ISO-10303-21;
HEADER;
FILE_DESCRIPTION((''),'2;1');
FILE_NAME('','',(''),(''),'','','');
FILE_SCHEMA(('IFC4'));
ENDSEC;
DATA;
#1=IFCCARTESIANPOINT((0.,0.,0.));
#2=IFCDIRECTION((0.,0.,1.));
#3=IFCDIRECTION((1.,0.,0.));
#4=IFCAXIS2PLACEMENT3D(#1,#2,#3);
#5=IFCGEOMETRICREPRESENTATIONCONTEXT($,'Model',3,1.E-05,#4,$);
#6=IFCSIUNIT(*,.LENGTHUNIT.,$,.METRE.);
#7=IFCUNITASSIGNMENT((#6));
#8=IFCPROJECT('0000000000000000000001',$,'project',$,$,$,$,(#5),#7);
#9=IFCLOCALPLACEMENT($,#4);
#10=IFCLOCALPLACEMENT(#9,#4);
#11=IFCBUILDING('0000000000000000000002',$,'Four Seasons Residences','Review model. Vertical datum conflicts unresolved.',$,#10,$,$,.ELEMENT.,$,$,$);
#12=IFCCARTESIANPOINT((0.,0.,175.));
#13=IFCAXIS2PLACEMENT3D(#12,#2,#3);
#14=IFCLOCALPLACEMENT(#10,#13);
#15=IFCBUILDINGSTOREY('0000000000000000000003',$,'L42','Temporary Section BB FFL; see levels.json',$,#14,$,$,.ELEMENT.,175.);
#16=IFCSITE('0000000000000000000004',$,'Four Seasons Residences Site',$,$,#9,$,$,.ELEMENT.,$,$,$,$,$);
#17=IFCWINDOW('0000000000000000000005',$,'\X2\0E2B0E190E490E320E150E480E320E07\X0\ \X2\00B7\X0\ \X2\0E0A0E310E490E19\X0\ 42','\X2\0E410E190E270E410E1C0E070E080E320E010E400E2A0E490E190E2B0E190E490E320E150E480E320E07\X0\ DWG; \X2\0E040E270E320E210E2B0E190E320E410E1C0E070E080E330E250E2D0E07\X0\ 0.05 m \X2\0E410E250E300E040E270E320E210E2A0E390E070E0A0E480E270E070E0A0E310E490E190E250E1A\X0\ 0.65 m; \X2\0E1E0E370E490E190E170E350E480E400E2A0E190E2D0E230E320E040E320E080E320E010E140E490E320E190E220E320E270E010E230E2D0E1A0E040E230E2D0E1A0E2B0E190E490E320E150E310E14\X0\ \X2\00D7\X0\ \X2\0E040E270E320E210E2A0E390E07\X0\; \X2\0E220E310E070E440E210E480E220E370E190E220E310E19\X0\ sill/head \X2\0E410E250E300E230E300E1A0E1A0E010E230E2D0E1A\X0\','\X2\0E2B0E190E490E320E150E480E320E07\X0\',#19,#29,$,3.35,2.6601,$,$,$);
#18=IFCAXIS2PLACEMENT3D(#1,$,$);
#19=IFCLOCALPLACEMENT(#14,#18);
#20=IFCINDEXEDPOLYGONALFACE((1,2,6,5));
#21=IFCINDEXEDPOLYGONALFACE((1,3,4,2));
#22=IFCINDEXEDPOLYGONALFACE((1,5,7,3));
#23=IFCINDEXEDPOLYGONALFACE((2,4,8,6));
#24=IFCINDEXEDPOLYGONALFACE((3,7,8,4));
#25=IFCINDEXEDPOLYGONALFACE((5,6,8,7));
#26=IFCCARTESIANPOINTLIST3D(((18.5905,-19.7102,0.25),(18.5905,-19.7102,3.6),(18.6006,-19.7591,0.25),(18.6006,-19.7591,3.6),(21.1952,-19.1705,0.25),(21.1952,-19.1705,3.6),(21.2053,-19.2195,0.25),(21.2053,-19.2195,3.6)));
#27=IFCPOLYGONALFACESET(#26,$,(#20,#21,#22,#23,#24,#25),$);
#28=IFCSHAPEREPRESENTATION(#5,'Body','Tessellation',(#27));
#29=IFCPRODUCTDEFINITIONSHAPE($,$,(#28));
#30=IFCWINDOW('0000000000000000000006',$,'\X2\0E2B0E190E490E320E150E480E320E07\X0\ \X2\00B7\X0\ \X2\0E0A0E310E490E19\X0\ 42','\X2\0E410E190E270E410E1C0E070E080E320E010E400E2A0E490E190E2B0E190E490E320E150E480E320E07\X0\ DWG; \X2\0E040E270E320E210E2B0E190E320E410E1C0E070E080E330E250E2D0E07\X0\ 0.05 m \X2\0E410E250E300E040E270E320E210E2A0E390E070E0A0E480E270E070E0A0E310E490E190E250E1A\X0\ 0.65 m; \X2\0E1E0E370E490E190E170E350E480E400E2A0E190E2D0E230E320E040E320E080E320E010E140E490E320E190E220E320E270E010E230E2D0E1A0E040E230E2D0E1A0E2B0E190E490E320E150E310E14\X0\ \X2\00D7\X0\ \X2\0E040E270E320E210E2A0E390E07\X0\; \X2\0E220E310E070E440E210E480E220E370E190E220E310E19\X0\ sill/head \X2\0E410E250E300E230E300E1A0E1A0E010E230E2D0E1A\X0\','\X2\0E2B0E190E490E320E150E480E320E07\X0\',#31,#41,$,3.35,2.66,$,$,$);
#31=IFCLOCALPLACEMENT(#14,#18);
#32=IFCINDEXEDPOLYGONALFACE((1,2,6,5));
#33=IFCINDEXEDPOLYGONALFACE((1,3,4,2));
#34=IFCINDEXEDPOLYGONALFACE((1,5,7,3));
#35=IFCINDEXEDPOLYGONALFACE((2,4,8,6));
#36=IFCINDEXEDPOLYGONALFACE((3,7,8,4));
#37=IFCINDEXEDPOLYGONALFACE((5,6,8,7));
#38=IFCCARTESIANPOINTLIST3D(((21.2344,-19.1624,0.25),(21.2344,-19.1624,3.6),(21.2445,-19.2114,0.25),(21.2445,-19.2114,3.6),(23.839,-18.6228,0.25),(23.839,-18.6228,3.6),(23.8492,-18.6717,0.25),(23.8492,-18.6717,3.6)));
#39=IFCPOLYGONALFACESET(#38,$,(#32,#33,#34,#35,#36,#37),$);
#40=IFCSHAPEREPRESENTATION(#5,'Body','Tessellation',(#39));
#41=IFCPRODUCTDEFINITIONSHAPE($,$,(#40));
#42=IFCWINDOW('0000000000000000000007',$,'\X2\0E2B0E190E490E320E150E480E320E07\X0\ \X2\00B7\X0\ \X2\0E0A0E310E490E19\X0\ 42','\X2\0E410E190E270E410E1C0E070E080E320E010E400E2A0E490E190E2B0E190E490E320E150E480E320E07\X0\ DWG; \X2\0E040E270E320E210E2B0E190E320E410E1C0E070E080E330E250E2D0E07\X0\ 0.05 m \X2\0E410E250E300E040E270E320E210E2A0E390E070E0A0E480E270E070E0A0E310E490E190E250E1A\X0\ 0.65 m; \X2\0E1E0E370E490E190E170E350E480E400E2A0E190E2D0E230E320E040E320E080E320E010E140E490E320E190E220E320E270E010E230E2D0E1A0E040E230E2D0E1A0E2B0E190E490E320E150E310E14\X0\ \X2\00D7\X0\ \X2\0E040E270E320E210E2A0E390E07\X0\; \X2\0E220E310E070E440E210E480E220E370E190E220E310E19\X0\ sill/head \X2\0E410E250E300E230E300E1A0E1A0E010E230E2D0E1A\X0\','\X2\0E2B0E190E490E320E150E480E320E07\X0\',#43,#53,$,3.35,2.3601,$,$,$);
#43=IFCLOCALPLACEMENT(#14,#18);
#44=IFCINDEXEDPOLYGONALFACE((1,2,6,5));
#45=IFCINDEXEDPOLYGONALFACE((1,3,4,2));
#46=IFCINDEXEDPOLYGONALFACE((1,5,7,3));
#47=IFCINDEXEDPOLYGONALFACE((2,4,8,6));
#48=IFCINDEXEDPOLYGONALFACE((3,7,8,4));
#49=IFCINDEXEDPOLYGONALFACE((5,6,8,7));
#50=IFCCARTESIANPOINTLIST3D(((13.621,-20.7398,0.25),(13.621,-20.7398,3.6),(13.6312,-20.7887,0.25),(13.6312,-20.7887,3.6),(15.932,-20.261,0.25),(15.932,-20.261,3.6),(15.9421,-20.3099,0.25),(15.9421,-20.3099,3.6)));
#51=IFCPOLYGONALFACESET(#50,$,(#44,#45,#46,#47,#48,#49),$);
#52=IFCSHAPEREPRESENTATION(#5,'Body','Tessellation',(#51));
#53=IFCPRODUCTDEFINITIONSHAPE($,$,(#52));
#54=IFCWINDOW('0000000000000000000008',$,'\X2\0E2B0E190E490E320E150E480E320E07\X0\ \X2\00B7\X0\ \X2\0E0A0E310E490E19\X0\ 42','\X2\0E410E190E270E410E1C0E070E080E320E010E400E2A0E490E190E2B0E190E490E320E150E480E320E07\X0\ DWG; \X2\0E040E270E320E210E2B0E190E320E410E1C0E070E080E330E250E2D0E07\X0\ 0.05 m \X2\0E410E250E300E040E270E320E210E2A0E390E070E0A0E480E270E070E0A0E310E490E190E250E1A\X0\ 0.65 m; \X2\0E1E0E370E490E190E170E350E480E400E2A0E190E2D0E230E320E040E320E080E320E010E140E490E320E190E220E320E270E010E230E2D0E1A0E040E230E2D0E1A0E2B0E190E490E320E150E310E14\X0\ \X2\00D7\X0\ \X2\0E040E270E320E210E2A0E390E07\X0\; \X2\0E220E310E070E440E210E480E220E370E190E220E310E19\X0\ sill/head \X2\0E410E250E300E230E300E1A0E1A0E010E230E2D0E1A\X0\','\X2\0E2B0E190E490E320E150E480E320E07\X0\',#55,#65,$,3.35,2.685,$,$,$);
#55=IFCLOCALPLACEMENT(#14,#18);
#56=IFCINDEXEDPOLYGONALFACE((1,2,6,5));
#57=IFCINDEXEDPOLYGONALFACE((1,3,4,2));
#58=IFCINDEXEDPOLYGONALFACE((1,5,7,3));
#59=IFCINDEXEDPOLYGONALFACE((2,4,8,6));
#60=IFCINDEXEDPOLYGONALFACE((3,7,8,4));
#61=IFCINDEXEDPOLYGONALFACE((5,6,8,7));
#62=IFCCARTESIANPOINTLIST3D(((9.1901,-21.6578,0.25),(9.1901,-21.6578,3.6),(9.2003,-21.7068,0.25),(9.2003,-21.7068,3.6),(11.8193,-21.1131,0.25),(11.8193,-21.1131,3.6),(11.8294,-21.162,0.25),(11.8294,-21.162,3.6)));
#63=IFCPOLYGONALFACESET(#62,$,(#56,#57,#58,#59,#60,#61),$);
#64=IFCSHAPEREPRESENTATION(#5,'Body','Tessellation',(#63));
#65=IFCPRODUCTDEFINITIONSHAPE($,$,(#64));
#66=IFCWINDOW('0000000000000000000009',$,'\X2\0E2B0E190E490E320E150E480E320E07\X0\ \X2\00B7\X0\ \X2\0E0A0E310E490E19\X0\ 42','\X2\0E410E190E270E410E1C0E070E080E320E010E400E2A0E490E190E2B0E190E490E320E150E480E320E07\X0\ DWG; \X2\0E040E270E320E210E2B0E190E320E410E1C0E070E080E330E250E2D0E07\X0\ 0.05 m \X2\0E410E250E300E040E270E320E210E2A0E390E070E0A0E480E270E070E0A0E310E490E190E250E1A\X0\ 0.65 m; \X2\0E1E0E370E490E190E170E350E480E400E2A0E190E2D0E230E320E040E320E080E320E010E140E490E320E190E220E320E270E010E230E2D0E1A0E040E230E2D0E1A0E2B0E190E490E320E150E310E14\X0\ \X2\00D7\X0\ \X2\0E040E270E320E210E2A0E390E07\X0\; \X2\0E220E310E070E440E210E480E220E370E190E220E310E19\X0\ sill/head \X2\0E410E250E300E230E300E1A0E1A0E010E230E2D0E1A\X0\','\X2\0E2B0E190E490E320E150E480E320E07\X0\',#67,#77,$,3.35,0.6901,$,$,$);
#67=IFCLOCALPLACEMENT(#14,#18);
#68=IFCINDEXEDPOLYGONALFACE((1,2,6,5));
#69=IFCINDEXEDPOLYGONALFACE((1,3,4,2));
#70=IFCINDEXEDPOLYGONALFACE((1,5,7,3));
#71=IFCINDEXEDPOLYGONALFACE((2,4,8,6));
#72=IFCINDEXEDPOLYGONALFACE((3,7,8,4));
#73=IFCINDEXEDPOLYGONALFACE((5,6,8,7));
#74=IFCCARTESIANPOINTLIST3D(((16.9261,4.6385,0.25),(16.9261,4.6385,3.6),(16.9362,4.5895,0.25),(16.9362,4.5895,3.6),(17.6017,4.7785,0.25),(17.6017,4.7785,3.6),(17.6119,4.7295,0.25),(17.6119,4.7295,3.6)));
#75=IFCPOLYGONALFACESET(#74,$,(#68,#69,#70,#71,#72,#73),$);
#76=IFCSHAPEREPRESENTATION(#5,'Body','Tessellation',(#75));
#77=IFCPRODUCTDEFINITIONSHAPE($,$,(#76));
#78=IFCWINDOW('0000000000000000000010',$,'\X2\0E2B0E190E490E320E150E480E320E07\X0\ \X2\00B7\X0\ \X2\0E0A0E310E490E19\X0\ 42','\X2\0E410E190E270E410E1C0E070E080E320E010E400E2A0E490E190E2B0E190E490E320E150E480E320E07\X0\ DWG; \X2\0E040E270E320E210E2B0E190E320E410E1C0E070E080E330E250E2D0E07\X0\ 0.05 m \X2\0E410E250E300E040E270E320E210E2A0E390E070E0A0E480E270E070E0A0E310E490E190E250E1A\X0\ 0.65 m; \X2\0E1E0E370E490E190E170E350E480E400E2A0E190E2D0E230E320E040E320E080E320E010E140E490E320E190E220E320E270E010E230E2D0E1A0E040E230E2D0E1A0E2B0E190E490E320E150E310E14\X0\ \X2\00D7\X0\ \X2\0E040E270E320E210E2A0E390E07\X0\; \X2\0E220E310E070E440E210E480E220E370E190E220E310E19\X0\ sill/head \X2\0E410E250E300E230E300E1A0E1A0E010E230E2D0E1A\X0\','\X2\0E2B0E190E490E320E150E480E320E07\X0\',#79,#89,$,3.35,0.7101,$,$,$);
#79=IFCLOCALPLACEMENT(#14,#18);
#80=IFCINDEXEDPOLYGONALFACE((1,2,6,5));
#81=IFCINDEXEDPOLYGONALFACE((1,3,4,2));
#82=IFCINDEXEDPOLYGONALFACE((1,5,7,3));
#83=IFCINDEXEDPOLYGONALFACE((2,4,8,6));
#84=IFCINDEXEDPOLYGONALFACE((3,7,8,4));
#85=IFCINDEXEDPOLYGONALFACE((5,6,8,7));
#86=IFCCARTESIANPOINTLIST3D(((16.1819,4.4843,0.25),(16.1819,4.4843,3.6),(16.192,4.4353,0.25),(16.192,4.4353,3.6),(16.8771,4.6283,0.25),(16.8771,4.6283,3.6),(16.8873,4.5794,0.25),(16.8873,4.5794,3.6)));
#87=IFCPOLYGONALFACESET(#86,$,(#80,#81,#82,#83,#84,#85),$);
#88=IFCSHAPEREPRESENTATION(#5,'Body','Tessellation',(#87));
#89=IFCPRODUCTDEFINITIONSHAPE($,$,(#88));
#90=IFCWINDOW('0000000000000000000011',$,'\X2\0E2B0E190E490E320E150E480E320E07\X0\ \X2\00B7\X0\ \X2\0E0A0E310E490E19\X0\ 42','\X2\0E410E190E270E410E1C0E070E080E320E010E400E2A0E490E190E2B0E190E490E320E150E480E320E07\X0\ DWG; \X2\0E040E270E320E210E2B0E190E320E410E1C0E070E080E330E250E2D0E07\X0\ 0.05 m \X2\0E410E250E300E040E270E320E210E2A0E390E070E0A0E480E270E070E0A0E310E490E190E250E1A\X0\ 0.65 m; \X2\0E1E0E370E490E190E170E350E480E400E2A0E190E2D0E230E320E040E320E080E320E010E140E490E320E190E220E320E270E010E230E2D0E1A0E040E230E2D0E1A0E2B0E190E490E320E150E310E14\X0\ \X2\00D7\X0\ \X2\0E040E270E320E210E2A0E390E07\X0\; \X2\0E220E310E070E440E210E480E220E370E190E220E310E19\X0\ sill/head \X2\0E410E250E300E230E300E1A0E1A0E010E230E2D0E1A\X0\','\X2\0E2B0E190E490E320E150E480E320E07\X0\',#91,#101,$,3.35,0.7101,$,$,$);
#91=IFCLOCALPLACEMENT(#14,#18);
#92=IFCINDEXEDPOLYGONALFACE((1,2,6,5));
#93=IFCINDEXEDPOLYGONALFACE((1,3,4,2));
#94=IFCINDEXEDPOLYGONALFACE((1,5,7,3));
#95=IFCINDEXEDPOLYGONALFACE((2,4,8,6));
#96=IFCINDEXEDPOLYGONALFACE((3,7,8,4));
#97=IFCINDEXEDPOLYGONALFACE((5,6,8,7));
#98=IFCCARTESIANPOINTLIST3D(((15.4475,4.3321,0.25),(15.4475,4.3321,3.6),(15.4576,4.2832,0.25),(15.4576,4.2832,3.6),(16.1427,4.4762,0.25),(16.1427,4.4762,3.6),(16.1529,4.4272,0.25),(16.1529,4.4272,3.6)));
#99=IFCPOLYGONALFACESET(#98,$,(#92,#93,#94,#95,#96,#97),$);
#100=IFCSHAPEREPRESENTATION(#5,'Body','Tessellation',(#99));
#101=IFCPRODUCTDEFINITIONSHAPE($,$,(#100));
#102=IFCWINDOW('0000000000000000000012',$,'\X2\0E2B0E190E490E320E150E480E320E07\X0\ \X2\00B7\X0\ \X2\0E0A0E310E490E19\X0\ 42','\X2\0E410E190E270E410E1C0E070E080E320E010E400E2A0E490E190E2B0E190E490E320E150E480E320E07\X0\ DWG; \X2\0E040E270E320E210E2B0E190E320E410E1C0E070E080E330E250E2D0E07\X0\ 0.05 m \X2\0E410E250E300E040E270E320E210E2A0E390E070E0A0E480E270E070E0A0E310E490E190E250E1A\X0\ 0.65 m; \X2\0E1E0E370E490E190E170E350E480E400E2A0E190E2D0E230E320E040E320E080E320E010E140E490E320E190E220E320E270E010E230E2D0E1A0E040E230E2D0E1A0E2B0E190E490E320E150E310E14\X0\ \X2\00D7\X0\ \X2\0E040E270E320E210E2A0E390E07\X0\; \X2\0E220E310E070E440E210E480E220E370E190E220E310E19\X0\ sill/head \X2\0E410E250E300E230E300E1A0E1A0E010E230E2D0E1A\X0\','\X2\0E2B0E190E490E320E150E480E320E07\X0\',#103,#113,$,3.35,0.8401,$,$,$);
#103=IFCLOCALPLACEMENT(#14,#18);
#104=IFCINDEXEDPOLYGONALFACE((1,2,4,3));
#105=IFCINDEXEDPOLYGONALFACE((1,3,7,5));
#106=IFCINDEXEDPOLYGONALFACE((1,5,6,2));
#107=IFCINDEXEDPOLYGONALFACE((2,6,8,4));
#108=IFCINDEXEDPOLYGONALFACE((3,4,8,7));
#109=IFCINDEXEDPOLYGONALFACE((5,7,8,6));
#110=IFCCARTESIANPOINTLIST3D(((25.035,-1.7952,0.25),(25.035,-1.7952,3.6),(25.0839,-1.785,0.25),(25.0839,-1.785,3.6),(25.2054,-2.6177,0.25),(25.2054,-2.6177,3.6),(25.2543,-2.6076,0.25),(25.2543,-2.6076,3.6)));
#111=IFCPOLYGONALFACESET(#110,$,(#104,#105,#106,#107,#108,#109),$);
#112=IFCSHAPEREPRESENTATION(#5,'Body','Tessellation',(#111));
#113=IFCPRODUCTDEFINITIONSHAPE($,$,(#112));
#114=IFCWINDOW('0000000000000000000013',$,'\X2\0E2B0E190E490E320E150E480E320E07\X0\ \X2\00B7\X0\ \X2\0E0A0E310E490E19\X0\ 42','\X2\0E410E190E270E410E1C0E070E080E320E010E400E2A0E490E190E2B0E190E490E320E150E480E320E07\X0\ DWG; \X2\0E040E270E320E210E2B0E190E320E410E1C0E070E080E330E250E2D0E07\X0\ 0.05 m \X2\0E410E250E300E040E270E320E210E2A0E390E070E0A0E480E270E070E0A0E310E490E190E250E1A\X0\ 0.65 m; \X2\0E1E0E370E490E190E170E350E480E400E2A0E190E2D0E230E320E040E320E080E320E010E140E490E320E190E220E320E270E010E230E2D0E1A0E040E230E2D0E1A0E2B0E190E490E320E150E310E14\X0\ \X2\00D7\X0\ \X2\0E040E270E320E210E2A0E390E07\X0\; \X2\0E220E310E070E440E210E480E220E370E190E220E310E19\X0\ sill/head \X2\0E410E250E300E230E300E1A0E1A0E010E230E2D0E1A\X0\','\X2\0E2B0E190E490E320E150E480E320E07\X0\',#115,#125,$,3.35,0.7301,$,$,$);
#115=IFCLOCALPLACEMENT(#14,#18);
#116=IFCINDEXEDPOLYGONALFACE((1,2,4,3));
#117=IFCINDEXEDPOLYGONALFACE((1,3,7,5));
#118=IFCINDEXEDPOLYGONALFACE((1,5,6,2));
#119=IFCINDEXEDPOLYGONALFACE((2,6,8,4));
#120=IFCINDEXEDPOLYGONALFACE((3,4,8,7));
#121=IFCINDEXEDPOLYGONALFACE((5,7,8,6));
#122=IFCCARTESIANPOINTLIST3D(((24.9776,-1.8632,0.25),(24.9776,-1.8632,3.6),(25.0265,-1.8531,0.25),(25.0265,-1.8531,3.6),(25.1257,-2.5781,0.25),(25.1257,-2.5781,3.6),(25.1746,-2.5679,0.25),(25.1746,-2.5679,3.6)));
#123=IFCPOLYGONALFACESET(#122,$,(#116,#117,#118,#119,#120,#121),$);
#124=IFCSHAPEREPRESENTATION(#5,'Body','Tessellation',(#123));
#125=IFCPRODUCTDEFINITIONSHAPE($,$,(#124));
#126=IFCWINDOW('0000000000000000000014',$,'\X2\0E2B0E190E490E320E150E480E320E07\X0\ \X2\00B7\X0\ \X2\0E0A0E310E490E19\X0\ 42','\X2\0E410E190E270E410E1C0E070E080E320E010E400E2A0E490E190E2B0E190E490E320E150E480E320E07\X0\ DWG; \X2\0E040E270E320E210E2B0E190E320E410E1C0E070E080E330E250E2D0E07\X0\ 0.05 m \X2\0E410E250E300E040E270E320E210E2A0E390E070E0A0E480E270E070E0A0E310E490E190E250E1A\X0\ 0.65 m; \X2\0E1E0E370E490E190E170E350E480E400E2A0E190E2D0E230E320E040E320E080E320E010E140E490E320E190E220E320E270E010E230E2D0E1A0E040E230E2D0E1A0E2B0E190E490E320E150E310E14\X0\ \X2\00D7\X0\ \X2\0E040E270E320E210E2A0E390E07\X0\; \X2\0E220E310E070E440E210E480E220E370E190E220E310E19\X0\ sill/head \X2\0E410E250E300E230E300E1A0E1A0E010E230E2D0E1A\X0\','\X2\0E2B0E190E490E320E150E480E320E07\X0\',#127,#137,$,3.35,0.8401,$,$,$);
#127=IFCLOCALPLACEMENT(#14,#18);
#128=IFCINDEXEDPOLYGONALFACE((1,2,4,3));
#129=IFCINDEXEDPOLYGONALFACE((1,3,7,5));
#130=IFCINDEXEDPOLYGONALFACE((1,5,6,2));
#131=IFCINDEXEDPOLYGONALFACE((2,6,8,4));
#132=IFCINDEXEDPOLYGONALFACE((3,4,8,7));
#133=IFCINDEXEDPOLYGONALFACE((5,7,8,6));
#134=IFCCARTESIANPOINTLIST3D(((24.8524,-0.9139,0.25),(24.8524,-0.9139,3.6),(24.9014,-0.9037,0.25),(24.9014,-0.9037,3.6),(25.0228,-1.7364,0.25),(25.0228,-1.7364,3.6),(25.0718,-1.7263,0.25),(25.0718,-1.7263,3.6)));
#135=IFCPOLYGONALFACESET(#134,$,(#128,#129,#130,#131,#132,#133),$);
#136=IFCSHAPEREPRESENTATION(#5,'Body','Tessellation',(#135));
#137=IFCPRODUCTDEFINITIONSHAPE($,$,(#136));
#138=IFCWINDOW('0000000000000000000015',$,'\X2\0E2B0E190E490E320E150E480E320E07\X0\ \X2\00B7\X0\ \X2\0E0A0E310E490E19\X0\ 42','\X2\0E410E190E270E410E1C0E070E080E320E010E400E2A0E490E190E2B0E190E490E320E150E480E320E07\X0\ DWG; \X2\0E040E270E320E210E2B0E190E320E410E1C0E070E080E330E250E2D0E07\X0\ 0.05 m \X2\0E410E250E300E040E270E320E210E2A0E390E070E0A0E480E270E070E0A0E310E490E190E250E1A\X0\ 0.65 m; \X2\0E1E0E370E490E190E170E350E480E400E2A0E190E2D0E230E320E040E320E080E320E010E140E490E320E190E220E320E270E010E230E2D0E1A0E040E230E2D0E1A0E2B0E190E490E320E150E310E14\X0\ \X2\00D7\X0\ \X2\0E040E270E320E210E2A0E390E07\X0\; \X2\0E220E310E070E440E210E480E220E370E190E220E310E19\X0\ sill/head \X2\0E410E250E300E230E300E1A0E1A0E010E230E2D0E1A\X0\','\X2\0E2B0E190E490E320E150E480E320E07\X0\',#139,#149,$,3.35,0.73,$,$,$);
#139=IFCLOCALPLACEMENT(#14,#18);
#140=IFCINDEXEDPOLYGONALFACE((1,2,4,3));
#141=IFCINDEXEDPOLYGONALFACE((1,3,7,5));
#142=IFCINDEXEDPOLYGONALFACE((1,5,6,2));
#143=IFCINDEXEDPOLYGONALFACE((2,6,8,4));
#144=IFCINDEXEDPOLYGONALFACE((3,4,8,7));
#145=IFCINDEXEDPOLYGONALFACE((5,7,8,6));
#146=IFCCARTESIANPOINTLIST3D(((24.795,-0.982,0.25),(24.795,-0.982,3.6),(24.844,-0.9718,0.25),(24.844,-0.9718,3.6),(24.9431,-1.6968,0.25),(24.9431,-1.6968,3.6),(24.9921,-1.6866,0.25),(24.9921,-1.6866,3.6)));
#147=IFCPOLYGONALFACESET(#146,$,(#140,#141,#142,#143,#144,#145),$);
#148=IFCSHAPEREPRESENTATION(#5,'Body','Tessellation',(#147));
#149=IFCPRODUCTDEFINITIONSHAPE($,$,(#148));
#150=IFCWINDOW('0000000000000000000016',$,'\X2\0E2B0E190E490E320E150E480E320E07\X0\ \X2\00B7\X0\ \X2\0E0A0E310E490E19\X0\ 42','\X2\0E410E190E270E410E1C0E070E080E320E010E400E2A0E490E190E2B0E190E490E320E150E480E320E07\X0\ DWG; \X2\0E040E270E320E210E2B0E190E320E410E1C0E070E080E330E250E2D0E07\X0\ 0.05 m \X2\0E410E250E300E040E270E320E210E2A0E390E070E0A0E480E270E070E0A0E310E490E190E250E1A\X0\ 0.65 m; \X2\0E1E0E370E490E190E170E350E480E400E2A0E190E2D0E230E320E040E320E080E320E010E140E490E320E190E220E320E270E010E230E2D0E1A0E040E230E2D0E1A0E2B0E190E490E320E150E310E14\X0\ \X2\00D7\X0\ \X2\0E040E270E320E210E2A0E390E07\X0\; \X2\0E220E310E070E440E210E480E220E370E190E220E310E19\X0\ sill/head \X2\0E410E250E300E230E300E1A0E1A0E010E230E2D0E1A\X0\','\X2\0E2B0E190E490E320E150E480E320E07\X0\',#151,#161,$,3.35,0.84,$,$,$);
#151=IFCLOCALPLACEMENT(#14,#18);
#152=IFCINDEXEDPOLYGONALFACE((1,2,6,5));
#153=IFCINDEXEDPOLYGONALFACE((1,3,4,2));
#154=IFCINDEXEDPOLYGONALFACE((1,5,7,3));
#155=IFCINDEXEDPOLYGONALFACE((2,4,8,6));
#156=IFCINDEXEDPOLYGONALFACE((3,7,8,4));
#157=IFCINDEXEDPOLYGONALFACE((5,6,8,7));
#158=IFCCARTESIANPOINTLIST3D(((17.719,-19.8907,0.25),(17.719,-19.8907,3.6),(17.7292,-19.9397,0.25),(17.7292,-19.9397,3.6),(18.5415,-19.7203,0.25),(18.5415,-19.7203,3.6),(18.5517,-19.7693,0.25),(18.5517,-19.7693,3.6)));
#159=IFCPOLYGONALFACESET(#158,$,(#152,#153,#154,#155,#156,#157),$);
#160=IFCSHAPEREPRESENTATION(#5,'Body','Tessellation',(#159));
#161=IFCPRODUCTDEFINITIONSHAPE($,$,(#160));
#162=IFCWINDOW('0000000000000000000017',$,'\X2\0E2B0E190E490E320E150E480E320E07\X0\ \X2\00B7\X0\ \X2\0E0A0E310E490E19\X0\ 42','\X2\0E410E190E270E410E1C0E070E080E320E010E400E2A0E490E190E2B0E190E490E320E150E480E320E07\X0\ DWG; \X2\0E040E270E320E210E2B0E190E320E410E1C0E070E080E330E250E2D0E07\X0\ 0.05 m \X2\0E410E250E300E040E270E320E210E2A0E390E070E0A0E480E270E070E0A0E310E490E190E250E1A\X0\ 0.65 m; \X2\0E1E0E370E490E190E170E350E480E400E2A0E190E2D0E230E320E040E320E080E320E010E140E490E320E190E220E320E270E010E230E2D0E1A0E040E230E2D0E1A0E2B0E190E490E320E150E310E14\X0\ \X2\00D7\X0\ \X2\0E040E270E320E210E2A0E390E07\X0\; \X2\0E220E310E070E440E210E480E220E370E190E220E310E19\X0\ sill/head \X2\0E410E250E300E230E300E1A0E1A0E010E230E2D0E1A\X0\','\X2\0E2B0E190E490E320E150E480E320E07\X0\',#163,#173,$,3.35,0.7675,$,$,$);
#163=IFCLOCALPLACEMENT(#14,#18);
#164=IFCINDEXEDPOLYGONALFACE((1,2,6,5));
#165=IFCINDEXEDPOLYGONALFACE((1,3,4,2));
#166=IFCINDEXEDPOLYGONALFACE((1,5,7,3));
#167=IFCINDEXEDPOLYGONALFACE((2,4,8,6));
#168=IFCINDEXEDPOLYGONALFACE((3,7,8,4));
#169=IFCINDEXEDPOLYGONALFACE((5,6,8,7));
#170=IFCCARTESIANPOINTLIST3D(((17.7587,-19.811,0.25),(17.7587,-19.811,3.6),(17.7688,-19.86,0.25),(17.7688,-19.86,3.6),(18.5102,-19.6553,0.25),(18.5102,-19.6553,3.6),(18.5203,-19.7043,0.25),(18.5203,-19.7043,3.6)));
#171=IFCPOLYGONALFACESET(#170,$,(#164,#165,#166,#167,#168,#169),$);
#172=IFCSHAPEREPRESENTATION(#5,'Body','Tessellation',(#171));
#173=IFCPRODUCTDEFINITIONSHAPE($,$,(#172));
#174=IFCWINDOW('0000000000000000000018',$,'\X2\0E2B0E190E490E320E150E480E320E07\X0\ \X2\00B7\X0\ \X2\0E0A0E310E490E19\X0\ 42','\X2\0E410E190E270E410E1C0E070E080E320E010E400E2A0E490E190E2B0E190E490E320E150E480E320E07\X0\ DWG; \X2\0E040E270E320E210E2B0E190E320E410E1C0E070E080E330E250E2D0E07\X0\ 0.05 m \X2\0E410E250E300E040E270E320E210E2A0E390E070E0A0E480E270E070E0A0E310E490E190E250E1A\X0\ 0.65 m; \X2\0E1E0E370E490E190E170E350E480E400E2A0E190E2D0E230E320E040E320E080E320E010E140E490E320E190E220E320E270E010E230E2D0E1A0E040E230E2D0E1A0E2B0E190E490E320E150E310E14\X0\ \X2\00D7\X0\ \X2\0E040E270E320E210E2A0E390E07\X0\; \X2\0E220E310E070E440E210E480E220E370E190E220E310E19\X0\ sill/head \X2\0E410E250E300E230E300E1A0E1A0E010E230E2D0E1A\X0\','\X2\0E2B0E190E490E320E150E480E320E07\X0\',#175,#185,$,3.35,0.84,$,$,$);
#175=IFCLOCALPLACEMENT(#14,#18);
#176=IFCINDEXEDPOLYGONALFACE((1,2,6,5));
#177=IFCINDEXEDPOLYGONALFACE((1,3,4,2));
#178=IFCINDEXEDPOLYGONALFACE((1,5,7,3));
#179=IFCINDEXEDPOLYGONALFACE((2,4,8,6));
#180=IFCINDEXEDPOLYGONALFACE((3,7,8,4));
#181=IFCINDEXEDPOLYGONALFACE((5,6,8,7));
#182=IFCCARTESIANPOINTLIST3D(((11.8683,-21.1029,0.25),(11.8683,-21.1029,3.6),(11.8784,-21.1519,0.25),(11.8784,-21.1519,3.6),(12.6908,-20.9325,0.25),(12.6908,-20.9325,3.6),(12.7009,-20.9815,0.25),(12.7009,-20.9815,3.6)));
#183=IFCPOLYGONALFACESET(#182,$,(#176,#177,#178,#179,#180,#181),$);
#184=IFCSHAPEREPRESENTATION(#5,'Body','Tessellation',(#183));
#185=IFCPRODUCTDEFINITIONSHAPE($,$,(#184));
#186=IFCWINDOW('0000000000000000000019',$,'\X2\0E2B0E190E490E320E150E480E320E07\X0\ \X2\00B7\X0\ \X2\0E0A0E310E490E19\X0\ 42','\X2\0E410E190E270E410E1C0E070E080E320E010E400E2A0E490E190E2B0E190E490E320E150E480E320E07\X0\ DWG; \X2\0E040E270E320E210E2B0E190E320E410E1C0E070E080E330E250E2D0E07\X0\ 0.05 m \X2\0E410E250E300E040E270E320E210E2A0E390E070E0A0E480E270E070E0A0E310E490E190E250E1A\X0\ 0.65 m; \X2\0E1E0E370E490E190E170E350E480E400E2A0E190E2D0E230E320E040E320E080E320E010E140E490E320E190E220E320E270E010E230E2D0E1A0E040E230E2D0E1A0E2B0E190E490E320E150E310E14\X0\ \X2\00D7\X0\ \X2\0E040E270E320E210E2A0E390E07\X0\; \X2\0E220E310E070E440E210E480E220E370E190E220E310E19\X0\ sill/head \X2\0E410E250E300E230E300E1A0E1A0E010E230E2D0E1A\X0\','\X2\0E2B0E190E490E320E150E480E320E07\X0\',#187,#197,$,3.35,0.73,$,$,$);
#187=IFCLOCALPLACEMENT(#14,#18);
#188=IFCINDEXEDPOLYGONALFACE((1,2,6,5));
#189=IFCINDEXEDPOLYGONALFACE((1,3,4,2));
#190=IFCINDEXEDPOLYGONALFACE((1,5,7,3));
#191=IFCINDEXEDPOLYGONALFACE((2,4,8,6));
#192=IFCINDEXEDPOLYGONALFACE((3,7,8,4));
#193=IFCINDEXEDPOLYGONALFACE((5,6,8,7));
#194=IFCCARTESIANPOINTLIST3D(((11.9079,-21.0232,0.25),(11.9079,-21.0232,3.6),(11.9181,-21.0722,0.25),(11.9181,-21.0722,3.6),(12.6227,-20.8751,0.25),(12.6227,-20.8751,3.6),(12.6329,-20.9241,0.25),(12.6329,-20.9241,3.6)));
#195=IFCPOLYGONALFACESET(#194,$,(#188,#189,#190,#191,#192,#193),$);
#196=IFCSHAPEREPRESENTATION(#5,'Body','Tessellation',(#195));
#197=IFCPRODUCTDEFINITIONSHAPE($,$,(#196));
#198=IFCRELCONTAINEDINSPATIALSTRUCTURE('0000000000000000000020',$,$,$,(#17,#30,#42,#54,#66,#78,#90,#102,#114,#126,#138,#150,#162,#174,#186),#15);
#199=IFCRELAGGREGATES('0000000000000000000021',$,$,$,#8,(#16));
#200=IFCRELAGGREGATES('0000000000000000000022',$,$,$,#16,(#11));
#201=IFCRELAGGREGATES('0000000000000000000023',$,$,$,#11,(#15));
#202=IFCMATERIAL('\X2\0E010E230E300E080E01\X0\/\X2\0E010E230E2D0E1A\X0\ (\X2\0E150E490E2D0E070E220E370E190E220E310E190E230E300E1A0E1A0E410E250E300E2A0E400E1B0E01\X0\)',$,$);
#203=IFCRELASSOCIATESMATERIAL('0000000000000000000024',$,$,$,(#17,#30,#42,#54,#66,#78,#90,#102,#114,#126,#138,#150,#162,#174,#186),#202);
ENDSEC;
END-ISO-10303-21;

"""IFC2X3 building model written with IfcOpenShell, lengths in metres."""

from ifc_helpers import new_model, si_unit, frame, origin_with_axes, place, context, project, spatial, polyline, outline, extrude, material, element, save


model = new_model("IFC2X3")

# Units and contexts
model_context = context("Model", 3, precision=1e-05, world=origin_with_axes())
ifc_project = project(units=[si_unit("LENGTHUNIT", "METRE")], contexts=[model_context])

# Site, building, storey
site_placement = place(None, origin_with_axes())
site = spatial("IfcSite", under=ifc_project, at=site_placement, Name="Four Seasons Residences Site", CompositionType="ELEMENT")
building_placement = place(site_placement, origin_with_axes())
building = spatial("IfcBuilding", under=site, at=building_placement, Name="Four Seasons Residences", Description="Review model. Vertical datum conflicts unresolved.", CompositionType="ELEMENT")
storey_placement = place(building_placement, frame((0.0, 0.0, 175.0), z_axis=(0.0, 0.0, 1.0), x_axis=(1.0, 0.0, 0.0)))
storey = spatial("IfcBuildingStorey", under=building, at=storey_placement, Name="L42", Description="Temporary Section BB FFL; see levels.json", CompositionType="ELEMENT", Elevation=175.0)

# Windows
ifc_material = material(Name="กระจก/กรอบ (ต้องยืนยันระบบและสเปก)")
window_1_placement = place(storey_placement, origin_with_axes())
element("IfcWindow", 1, at=window_1_placement, inside=storey, material=ifc_material, Name="หน้าต่าง · ชั้น 42", Description="แนวแผงจากเส้นหน้าต่าง DWG; ความหนาแผงจำลอง 0.05 m และความสูงช่วงชั้นลบ 0.65 m; พื้นที่เสนอราคาจากด้านยาวกรอบครอบหน้าตัด × ความสูง; ยังไม่ยืนยัน sill/head และระบบกรอบ", ObjectType="หน้าต่าง", OverallHeight=3.35, OverallWidth=2.6601, context=model_context, shape_type="SweptSolid", body=[
    extrude(outline(polyline([(18.6006, -19.7591), (18.5905, -19.7102), (21.1952, -19.1705), (21.2053, -19.2195), (18.6006, -19.7591)])), frame((0.0, 0.0, 0.25), z_axis=(0.0, 0.0, 1.0), x_axis=(1.0, 0.0, 0.0)), (0.0, 0.0, 1.0), 3.35),
])
window_2_placement = place(storey_placement, origin_with_axes())
element("IfcWindow", 2, at=window_2_placement, inside=storey, material=ifc_material, Name="หน้าต่าง · ชั้น 42", Description="แนวแผงจากเส้นหน้าต่าง DWG; ความหนาแผงจำลอง 0.05 m และความสูงช่วงชั้นลบ 0.65 m; พื้นที่เสนอราคาจากด้านยาวกรอบครอบหน้าตัด × ความสูง; ยังไม่ยืนยัน sill/head และระบบกรอบ", ObjectType="หน้าต่าง", OverallHeight=3.35, OverallWidth=2.66, context=model_context, shape_type="SweptSolid", body=[
    extrude(outline(polyline([(21.2445, -19.2114), (21.2344, -19.1624), (23.839, -18.6228), (23.8492, -18.6717), (21.2445, -19.2114)])), frame((0.0, 0.0, 0.25), z_axis=(0.0, 0.0, 1.0), x_axis=(1.0, 0.0, 0.0)), (0.0, 0.0, 1.0), 3.35),
])
window_3_placement = place(storey_placement, origin_with_axes())
element("IfcWindow", 3, at=window_3_placement, inside=storey, material=ifc_material, Name="หน้าต่าง · ชั้น 42", Description="แนวแผงจากเส้นหน้าต่าง DWG; ความหนาแผงจำลอง 0.05 m และความสูงช่วงชั้นลบ 0.65 m; พื้นที่เสนอราคาจากด้านยาวกรอบครอบหน้าตัด × ความสูง; ยังไม่ยืนยัน sill/head และระบบกรอบ", ObjectType="หน้าต่าง", OverallHeight=3.35, OverallWidth=2.3601, context=model_context, shape_type="SweptSolid", body=[
    extrude(outline(polyline([(13.6312, -20.7887), (13.621, -20.7398), (15.932, -20.261), (15.9421, -20.3099), (13.6312, -20.7887)])), frame((0.0, 0.0, 0.25), z_axis=(0.0, 0.0, 1.0), x_axis=(1.0, 0.0, 0.0)), (0.0, 0.0, 1.0), 3.35),
])
window_4_placement = place(storey_placement, origin_with_axes())
element("IfcWindow", 4, at=window_4_placement, inside=storey, material=ifc_material, Name="หน้าต่าง · ชั้น 42", Description="แนวแผงจากเส้นหน้าต่าง DWG; ความหนาแผงจำลอง 0.05 m และความสูงช่วงชั้นลบ 0.65 m; พื้นที่เสนอราคาจากด้านยาวกรอบครอบหน้าตัด × ความสูง; ยังไม่ยืนยัน sill/head และระบบกรอบ", ObjectType="หน้าต่าง", OverallHeight=3.35, OverallWidth=2.685, context=model_context, shape_type="SweptSolid", body=[
    extrude(outline(polyline([(9.2003, -21.7068), (9.1901, -21.6578), (11.8193, -21.1131), (11.8294, -21.162), (9.2003, -21.7068)])), frame((0.0, 0.0, 0.25), z_axis=(0.0, 0.0, 1.0), x_axis=(1.0, 0.0, 0.0)), (0.0, 0.0, 1.0), 3.35),
])
window_5_placement = place(storey_placement, origin_with_axes())
element("IfcWindow", 5, at=window_5_placement, inside=storey, material=ifc_material, Name="หน้าต่าง · ชั้น 42", Description="แนวแผงจากเส้นหน้าต่าง DWG; ความหนาแผงจำลอง 0.05 m และความสูงช่วงชั้นลบ 0.65 m; พื้นที่เสนอราคาจากด้านยาวกรอบครอบหน้าตัด × ความสูง; ยังไม่ยืนยัน sill/head และระบบกรอบ", ObjectType="หน้าต่าง", OverallHeight=3.35, OverallWidth=0.6901, context=model_context, shape_type="SweptSolid", body=[
    extrude(outline(polyline([(16.9362, 4.5895), (16.9261, 4.6385), (17.6017, 4.7785), (17.6119, 4.7295), (16.9362, 4.5895)])), frame((0.0, 0.0, 0.25), z_axis=(0.0, 0.0, 1.0), x_axis=(1.0, 0.0, 0.0)), (0.0, 0.0, 1.0), 3.35),
])
window_6_placement = place(storey_placement, origin_with_axes())
element("IfcWindow", 6, at=window_6_placement, inside=storey, material=ifc_material, Name="หน้าต่าง · ชั้น 42", Description="แนวแผงจากเส้นหน้าต่าง DWG; ความหนาแผงจำลอง 0.05 m และความสูงช่วงชั้นลบ 0.65 m; พื้นที่เสนอราคาจากด้านยาวกรอบครอบหน้าตัด × ความสูง; ยังไม่ยืนยัน sill/head และระบบกรอบ", ObjectType="หน้าต่าง", OverallHeight=3.35, OverallWidth=0.7101, context=model_context, shape_type="SweptSolid", body=[
    extrude(outline(polyline([(16.192, 4.4353), (16.1819, 4.4843), (16.8771, 4.6283), (16.8873, 4.5794), (16.192, 4.4353)])), frame((0.0, 0.0, 0.25), z_axis=(0.0, 0.0, 1.0), x_axis=(1.0, 0.0, 0.0)), (0.0, 0.0, 1.0), 3.35),
])
window_7_placement = place(storey_placement, origin_with_axes())
element("IfcWindow", 7, at=window_7_placement, inside=storey, material=ifc_material, Name="หน้าต่าง · ชั้น 42", Description="แนวแผงจากเส้นหน้าต่าง DWG; ความหนาแผงจำลอง 0.05 m และความสูงช่วงชั้นลบ 0.65 m; พื้นที่เสนอราคาจากด้านยาวกรอบครอบหน้าตัด × ความสูง; ยังไม่ยืนยัน sill/head และระบบกรอบ", ObjectType="หน้าต่าง", OverallHeight=3.35, OverallWidth=0.7101, context=model_context, shape_type="SweptSolid", body=[
    extrude(outline(polyline([(15.4576, 4.2832), (15.4475, 4.3321), (16.1427, 4.4762), (16.1529, 4.4272), (15.4576, 4.2832)])), frame((0.0, 0.0, 0.25), z_axis=(0.0, 0.0, 1.0), x_axis=(1.0, 0.0, 0.0)), (0.0, 0.0, 1.0), 3.35),
])
window_8_placement = place(storey_placement, origin_with_axes())
element("IfcWindow", 8, at=window_8_placement, inside=storey, material=ifc_material, Name="หน้าต่าง · ชั้น 42", Description="แนวแผงจากเส้นหน้าต่าง DWG; ความหนาแผงจำลอง 0.05 m และความสูงช่วงชั้นลบ 0.65 m; พื้นที่เสนอราคาจากด้านยาวกรอบครอบหน้าตัด × ความสูง; ยังไม่ยืนยัน sill/head และระบบกรอบ", ObjectType="หน้าต่าง", OverallHeight=3.35, OverallWidth=0.8401, context=model_context, shape_type="SweptSolid", body=[
    extrude(outline(polyline([(25.035, -1.7952), (25.0839, -1.785), (25.2543, -2.6076), (25.2054, -2.6177), (25.035, -1.7952)])), frame((0.0, 0.0, 0.25), z_axis=(0.0, 0.0, 1.0), x_axis=(1.0, 0.0, 0.0)), (0.0, 0.0, 1.0), 3.35),
])
window_9_placement = place(storey_placement, origin_with_axes())
element("IfcWindow", 9, at=window_9_placement, inside=storey, material=ifc_material, Name="หน้าต่าง · ชั้น 42", Description="แนวแผงจากเส้นหน้าต่าง DWG; ความหนาแผงจำลอง 0.05 m และความสูงช่วงชั้นลบ 0.65 m; พื้นที่เสนอราคาจากด้านยาวกรอบครอบหน้าตัด × ความสูง; ยังไม่ยืนยัน sill/head และระบบกรอบ", ObjectType="หน้าต่าง", OverallHeight=3.35, OverallWidth=0.7301, context=model_context, shape_type="SweptSolid", body=[
    extrude(outline(polyline([(24.9776, -1.8632), (25.0265, -1.8531), (25.1746, -2.5679), (25.1257, -2.5781), (24.9776, -1.8632)])), frame((0.0, 0.0, 0.25), z_axis=(0.0, 0.0, 1.0), x_axis=(1.0, 0.0, 0.0)), (0.0, 0.0, 1.0), 3.35),
])
window_10_placement = place(storey_placement, origin_with_axes())
element("IfcWindow", 10, at=window_10_placement, inside=storey, material=ifc_material, Name="หน้าต่าง · ชั้น 42", Description="แนวแผงจากเส้นหน้าต่าง DWG; ความหนาแผงจำลอง 0.05 m และความสูงช่วงชั้นลบ 0.65 m; พื้นที่เสนอราคาจากด้านยาวกรอบครอบหน้าตัด × ความสูง; ยังไม่ยืนยัน sill/head และระบบกรอบ", ObjectType="หน้าต่าง", OverallHeight=3.35, OverallWidth=0.8401, context=model_context, shape_type="SweptSolid", body=[
    extrude(outline(polyline([(24.8524, -0.9139), (24.9014, -0.9037), (25.0718, -1.7263), (25.0228, -1.7364), (24.8524, -0.9139)])), frame((0.0, 0.0, 0.25), z_axis=(0.0, 0.0, 1.0), x_axis=(1.0, 0.0, 0.0)), (0.0, 0.0, 1.0), 3.35),
])
window_11_placement = place(storey_placement, origin_with_axes())
element("IfcWindow", 11, at=window_11_placement, inside=storey, material=ifc_material, Name="หน้าต่าง · ชั้น 42", Description="แนวแผงจากเส้นหน้าต่าง DWG; ความหนาแผงจำลอง 0.05 m และความสูงช่วงชั้นลบ 0.65 m; พื้นที่เสนอราคาจากด้านยาวกรอบครอบหน้าตัด × ความสูง; ยังไม่ยืนยัน sill/head และระบบกรอบ", ObjectType="หน้าต่าง", OverallHeight=3.35, OverallWidth=0.73, context=model_context, shape_type="SweptSolid", body=[
    extrude(outline(polyline([(24.795, -0.982), (24.844, -0.9718), (24.9921, -1.6866), (24.9431, -1.6968), (24.795, -0.982)])), frame((0.0, 0.0, 0.25), z_axis=(0.0, 0.0, 1.0), x_axis=(1.0, 0.0, 0.0)), (0.0, 0.0, 1.0), 3.35),
])
window_12_placement = place(storey_placement, origin_with_axes())
element("IfcWindow", 12, at=window_12_placement, inside=storey, material=ifc_material, Name="หน้าต่าง · ชั้น 42", Description="แนวแผงจากเส้นหน้าต่าง DWG; ความหนาแผงจำลอง 0.05 m และความสูงช่วงชั้นลบ 0.65 m; พื้นที่เสนอราคาจากด้านยาวกรอบครอบหน้าตัด × ความสูง; ยังไม่ยืนยัน sill/head และระบบกรอบ", ObjectType="หน้าต่าง", OverallHeight=3.35, OverallWidth=0.84, context=model_context, shape_type="SweptSolid", body=[
    extrude(outline(polyline([(17.7292, -19.9397), (17.719, -19.8907), (18.5415, -19.7203), (18.5517, -19.7693), (17.7292, -19.9397)])), frame((0.0, 0.0, 0.25), z_axis=(0.0, 0.0, 1.0), x_axis=(1.0, 0.0, 0.0)), (0.0, 0.0, 1.0), 3.35),
])
window_13_placement = place(storey_placement, origin_with_axes())
element("IfcWindow", 13, at=window_13_placement, inside=storey, material=ifc_material, Name="หน้าต่าง · ชั้น 42", Description="แนวแผงจากเส้นหน้าต่าง DWG; ความหนาแผงจำลอง 0.05 m และความสูงช่วงชั้นลบ 0.65 m; พื้นที่เสนอราคาจากด้านยาวกรอบครอบหน้าตัด × ความสูง; ยังไม่ยืนยัน sill/head และระบบกรอบ", ObjectType="หน้าต่าง", OverallHeight=3.35, OverallWidth=0.7675, context=model_context, shape_type="SweptSolid", body=[
    extrude(outline(polyline([(17.7688, -19.86), (17.7587, -19.811), (18.5102, -19.6553), (18.5203, -19.7043), (17.7688, -19.86)])), frame((0.0, 0.0, 0.25), z_axis=(0.0, 0.0, 1.0), x_axis=(1.0, 0.0, 0.0)), (0.0, 0.0, 1.0), 3.35),
])
window_14_placement = place(storey_placement, origin_with_axes())
element("IfcWindow", 14, at=window_14_placement, inside=storey, material=ifc_material, Name="หน้าต่าง · ชั้น 42", Description="แนวแผงจากเส้นหน้าต่าง DWG; ความหนาแผงจำลอง 0.05 m และความสูงช่วงชั้นลบ 0.65 m; พื้นที่เสนอราคาจากด้านยาวกรอบครอบหน้าตัด × ความสูง; ยังไม่ยืนยัน sill/head และระบบกรอบ", ObjectType="หน้าต่าง", OverallHeight=3.35, OverallWidth=0.84, context=model_context, shape_type="SweptSolid", body=[
    extrude(outline(polyline([(12.6908, -20.9325), (12.7009, -20.9815), (11.8784, -21.1519), (11.8683, -21.1029), (12.6908, -20.9325)])), frame((0.0, 0.0, 0.25), z_axis=(0.0, 0.0, 1.0), x_axis=(1.0, 0.0, 0.0)), (0.0, 0.0, 1.0), 3.35),
])
window_15_placement = place(storey_placement, origin_with_axes())
element("IfcWindow", 15, at=window_15_placement, inside=storey, material=ifc_material, Name="หน้าต่าง · ชั้น 42", Description="แนวแผงจากเส้นหน้าต่าง DWG; ความหนาแผงจำลอง 0.05 m และความสูงช่วงชั้นลบ 0.65 m; พื้นที่เสนอราคาจากด้านยาวกรอบครอบหน้าตัด × ความสูง; ยังไม่ยืนยัน sill/head และระบบกรอบ", ObjectType="หน้าต่าง", OverallHeight=3.35, OverallWidth=0.73, context=model_context, shape_type="SweptSolid", body=[
    extrude(outline(polyline([(12.6227, -20.8751), (12.6329, -20.9241), (11.9181, -21.0722), (11.9079, -21.0232), (12.6227, -20.8751)])), frame((0.0, 0.0, 0.25), z_axis=(0.0, 0.0, 1.0), x_axis=(1.0, 0.0, 0.0)), (0.0, 0.0, 1.0), 3.35),
])

save(model, "model.ifc")
